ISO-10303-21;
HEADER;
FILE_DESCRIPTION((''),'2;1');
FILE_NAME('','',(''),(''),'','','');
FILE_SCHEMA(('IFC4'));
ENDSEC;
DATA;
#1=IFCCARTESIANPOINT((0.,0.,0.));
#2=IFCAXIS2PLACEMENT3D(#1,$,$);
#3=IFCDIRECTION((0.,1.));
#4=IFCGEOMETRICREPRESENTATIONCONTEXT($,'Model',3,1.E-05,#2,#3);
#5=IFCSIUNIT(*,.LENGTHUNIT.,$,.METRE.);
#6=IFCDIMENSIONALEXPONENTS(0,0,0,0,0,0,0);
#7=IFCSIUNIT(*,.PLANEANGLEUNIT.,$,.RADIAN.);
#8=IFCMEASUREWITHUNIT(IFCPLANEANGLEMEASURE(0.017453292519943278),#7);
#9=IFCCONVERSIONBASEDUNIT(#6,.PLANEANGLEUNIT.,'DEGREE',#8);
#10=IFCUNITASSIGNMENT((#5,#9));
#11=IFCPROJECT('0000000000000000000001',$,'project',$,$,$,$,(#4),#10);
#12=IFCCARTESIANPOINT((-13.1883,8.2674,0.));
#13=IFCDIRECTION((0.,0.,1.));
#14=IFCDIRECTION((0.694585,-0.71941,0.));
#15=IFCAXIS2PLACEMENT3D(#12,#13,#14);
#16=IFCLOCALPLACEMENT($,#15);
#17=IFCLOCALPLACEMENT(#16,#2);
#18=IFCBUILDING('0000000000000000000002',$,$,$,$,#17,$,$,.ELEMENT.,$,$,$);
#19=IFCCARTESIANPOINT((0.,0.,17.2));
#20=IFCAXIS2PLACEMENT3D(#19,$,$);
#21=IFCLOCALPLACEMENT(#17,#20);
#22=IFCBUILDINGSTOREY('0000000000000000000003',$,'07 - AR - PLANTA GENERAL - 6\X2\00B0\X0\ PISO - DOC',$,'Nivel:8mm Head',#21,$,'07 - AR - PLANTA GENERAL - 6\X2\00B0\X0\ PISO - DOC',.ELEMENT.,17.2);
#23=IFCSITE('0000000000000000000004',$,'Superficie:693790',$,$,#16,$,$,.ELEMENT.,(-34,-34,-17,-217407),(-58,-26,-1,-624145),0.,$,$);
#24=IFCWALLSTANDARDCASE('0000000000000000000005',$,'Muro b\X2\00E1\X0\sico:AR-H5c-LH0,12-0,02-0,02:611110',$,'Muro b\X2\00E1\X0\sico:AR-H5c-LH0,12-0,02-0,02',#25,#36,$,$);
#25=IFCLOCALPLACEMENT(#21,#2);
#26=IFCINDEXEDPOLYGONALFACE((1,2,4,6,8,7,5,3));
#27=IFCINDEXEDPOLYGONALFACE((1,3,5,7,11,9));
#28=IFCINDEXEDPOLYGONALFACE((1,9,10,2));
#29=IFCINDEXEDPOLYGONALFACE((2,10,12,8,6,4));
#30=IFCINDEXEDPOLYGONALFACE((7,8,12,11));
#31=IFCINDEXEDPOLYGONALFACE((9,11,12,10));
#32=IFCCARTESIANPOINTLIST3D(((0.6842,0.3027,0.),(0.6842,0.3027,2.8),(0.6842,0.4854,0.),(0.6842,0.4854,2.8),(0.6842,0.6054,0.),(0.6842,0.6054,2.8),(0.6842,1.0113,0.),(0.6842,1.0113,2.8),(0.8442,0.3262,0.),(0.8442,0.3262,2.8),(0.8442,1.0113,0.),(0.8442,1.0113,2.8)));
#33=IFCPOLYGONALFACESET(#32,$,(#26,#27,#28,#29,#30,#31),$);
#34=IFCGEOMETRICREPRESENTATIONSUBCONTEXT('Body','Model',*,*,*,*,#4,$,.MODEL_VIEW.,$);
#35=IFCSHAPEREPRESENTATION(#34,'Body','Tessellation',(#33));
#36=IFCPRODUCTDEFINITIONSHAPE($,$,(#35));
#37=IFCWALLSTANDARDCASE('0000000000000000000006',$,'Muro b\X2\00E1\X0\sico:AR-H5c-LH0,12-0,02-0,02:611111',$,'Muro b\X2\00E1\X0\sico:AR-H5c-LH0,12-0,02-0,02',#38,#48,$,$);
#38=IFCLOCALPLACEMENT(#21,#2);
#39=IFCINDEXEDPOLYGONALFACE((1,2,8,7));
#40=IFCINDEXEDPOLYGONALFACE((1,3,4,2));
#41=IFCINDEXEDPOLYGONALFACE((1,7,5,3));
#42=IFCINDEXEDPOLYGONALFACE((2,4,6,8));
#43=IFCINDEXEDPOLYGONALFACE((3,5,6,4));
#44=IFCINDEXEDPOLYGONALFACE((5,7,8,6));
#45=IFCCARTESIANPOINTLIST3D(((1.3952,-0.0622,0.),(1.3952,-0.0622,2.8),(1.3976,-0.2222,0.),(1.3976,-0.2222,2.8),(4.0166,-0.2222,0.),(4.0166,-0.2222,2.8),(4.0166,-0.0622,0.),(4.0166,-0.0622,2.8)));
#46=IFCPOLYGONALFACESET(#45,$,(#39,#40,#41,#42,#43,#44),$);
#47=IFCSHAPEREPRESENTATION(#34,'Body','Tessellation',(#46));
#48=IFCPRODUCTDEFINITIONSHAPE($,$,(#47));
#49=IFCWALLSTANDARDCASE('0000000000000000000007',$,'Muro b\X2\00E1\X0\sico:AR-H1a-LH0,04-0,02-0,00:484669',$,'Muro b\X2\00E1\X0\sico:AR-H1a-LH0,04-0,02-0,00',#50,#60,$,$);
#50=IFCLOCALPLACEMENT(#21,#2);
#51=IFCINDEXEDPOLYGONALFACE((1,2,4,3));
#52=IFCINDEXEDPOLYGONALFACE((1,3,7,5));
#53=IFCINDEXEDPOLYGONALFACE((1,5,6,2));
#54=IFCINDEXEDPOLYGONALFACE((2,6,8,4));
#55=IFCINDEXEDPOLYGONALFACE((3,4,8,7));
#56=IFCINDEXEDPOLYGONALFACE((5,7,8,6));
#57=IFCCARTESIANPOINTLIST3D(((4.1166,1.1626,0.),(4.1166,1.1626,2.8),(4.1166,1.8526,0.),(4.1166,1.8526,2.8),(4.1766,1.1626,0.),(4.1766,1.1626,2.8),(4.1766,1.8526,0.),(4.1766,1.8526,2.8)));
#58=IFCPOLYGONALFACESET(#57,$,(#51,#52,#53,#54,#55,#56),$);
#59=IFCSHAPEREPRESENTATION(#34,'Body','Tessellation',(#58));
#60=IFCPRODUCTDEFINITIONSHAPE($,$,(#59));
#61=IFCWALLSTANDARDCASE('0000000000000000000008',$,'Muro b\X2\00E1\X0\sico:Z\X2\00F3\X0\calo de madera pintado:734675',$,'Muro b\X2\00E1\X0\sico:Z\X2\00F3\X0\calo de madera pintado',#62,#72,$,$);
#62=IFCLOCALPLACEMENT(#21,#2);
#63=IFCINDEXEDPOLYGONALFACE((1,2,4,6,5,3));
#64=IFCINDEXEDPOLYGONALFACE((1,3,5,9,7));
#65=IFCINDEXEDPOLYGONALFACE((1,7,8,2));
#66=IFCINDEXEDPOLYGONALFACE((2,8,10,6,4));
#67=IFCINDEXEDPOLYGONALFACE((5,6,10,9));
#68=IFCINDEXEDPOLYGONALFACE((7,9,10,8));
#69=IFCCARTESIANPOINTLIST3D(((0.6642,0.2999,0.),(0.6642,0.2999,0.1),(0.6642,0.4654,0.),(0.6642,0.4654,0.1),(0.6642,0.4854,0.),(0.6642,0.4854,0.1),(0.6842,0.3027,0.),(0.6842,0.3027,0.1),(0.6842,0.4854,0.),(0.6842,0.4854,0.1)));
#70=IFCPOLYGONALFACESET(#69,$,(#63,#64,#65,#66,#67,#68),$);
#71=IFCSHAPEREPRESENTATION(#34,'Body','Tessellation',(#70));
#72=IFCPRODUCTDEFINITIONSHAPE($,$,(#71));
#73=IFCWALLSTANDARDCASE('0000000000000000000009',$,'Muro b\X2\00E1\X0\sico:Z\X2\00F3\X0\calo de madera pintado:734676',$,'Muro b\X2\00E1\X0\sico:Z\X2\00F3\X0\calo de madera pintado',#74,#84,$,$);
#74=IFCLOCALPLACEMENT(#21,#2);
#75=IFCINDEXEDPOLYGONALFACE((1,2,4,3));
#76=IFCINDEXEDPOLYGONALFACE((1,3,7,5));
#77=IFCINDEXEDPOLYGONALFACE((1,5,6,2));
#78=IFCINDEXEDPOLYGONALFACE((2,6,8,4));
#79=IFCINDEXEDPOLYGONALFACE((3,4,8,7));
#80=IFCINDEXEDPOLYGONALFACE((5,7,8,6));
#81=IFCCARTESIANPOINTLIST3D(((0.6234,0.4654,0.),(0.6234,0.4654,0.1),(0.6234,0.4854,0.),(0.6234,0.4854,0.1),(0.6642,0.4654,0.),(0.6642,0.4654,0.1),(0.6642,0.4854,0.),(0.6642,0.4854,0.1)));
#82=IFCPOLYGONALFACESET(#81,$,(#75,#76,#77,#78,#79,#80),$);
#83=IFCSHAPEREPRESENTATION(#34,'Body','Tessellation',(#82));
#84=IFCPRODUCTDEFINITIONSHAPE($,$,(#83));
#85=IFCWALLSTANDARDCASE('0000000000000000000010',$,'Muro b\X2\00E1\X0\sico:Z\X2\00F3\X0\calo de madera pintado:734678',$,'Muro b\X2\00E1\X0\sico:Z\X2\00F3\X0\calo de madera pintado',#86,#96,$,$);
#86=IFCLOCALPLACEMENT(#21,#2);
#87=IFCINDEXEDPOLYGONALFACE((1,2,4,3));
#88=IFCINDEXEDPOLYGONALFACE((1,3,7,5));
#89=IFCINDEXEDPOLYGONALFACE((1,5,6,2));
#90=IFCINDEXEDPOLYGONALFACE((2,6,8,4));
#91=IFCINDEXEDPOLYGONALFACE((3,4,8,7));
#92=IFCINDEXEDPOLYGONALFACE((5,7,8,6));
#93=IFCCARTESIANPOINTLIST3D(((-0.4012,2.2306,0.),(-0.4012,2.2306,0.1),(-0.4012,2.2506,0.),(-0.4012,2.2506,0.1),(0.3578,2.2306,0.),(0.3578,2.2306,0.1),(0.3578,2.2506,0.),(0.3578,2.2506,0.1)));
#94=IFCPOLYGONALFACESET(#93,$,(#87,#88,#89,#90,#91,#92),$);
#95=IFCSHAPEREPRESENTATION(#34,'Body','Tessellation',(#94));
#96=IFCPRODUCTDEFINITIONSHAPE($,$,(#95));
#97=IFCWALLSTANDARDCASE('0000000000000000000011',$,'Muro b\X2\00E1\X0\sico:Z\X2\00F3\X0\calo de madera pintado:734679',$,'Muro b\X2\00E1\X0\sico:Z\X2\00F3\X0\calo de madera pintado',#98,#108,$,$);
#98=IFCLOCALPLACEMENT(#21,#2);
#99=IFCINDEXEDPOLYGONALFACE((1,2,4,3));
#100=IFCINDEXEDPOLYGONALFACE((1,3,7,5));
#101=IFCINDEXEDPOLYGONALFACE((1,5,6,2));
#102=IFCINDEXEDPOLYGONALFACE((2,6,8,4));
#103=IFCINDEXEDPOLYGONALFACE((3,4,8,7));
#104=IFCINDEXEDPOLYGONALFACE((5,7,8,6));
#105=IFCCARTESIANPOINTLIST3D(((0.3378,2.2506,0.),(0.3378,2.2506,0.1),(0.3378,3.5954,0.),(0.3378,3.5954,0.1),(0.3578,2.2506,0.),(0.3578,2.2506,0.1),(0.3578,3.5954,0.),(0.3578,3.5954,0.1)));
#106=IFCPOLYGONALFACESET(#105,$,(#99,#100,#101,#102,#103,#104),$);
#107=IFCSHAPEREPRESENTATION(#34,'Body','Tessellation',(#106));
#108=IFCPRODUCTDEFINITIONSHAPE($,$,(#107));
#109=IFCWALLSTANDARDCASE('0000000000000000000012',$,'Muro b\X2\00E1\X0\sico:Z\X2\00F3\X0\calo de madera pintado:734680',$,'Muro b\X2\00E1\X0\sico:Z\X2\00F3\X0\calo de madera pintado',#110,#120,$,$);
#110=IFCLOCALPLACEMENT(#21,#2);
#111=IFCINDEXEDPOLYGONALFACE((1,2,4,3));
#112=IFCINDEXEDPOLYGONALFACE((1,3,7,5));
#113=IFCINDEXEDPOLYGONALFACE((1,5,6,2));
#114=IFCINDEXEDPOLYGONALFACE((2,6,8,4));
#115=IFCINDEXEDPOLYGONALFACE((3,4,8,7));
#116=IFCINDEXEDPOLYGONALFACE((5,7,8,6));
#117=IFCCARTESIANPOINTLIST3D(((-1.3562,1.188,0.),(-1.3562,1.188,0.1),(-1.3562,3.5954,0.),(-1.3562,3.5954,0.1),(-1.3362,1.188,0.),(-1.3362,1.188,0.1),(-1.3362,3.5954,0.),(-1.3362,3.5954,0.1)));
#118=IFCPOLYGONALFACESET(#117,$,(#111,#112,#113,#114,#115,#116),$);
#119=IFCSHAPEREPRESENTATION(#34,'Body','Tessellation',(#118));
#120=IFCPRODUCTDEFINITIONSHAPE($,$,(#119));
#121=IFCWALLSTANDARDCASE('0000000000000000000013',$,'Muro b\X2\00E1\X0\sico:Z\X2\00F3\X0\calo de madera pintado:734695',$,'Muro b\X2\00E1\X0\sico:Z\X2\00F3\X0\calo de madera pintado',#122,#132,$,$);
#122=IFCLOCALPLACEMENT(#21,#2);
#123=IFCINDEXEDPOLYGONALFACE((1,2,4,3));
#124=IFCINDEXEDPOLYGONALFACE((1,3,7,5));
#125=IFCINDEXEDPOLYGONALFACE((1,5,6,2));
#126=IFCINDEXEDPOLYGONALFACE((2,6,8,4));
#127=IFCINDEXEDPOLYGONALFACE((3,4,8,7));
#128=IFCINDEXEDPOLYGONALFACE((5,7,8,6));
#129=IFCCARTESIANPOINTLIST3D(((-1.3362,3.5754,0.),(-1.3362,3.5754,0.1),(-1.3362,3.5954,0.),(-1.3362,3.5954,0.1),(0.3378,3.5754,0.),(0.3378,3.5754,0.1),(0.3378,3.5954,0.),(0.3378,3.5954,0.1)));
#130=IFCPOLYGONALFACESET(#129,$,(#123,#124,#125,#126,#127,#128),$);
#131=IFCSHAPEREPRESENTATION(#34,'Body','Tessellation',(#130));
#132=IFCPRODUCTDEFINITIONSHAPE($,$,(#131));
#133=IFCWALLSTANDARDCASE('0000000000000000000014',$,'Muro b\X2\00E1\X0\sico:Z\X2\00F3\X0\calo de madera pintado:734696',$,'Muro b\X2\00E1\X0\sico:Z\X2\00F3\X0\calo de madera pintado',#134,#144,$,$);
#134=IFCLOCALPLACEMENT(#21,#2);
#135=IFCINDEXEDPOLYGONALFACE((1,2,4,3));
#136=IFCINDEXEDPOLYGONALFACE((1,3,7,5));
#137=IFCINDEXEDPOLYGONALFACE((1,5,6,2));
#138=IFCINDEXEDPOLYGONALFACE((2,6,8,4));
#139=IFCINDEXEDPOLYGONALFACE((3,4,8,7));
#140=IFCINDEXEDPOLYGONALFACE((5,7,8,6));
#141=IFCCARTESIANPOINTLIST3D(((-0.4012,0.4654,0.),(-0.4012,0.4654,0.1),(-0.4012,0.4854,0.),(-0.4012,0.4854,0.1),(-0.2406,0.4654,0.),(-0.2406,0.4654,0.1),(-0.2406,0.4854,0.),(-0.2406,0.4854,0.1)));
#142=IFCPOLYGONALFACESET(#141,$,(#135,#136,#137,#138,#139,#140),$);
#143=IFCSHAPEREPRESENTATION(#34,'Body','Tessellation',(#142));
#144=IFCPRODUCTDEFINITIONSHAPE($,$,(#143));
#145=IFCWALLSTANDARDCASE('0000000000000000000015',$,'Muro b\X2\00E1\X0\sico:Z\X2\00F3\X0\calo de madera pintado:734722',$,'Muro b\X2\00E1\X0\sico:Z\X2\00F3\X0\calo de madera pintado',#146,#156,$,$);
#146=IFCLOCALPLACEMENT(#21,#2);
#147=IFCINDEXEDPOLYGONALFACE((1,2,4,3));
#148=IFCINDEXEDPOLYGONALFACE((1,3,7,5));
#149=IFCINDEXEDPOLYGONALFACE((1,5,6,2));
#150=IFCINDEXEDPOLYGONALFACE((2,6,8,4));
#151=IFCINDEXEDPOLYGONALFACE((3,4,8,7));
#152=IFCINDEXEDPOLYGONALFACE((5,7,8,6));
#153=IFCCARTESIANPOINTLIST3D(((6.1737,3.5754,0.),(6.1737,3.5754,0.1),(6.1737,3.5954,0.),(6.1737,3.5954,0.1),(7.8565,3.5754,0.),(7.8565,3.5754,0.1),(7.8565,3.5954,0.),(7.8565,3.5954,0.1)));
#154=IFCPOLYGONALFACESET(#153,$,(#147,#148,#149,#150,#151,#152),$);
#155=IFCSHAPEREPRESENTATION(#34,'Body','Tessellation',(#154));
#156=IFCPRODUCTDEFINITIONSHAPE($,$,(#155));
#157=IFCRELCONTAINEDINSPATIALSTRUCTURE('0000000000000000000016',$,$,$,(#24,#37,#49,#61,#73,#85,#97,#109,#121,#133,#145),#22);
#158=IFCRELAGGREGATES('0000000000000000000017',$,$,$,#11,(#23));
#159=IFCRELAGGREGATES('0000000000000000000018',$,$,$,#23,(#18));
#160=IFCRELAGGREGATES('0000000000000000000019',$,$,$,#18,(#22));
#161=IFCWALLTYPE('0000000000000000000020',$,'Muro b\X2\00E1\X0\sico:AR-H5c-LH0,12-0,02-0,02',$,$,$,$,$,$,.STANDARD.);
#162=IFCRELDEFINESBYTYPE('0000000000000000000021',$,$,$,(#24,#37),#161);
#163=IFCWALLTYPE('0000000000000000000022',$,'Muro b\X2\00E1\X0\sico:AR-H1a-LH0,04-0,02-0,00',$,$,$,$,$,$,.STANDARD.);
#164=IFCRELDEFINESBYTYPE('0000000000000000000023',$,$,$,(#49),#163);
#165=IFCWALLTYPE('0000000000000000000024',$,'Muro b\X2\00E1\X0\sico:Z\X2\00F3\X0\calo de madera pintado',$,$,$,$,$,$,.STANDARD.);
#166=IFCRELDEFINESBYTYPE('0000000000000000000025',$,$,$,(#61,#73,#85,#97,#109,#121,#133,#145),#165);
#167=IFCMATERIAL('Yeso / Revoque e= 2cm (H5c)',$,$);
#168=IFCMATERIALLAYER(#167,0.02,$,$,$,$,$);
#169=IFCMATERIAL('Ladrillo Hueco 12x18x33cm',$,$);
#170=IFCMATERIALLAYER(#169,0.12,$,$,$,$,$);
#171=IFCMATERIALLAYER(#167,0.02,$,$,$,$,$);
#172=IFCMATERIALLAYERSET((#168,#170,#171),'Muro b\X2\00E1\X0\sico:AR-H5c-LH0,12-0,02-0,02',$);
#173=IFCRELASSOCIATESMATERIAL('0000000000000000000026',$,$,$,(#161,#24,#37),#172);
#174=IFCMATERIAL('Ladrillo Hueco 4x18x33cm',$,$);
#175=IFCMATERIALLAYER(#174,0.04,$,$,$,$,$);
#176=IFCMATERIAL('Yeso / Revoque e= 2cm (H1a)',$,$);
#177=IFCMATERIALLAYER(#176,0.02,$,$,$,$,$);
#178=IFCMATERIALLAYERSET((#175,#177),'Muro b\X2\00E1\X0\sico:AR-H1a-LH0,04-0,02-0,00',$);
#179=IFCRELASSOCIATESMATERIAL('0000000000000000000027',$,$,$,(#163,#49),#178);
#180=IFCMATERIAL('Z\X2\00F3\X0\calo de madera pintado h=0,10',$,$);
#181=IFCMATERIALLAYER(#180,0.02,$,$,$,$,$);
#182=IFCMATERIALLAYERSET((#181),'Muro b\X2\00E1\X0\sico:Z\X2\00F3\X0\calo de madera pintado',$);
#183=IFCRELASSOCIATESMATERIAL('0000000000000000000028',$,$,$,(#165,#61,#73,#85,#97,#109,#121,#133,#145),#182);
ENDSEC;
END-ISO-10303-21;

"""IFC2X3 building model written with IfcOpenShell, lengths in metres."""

from ifc_helpers import new_model, entity, si_unit, converted_unit, direction, frame, frame_2d, origin, place, context, subcontext, project, spatial, polyline, rectangle, outline, extrude, material, layer, layer_set, layer_usage, type_object, element, save


model = new_model("IFC2X3")

# Units and contexts
model_context = context("Model", 3, precision=1e-05, world=origin(), true_north=direction((0.0, 1.0)))
body_context = subcontext(model_context, "Body", "Model", "MODEL_VIEW")
ifc_project = project(units=[si_unit("LENGTHUNIT", "METRE"), converted_unit("PLANEANGLEUNIT", "DEGREE", entity("IfcPlaneAngleMeasure", 0.017453292519943278), si_unit("PLANEANGLEUNIT", "RADIAN"), dimensions=[0, 0, 0, 0, 0, 0, 0])], contexts=[model_context])

# Site, building, storey
site_placement = place(None, frame((-13.1883, 8.2674, 0.0), z_axis=(0.0, 0.0, 1.0), x_axis=(0.694585, -0.71941, 0.0)))
site = spatial("IfcSite", under=ifc_project, at=site_placement, Name="Superficie:693790", CompositionType="ELEMENT", RefLatitude=(-34, -34, -17, -217407), RefLongitude=(-58, -26, -1, -624145), RefElevation=0.0)
building_placement = place(site_placement, origin())
building = spatial("IfcBuilding", under=site, at=building_placement, CompositionType="ELEMENT")
storey_placement = place(building_placement, frame((0.0, 0.0, 17.2)))
storey = spatial("IfcBuildingStorey", under=building, at=storey_placement, Name="07 - AR - PLANTA GENERAL - 6° PISO - DOC", ObjectType="Nivel:8mm Head", LongName="07 - AR - PLANTA GENERAL - 6° PISO - DOC", CompositionType="ELEMENT", Elevation=17.2)

# Walls
ifc_material_1 = material(Name="Yeso / Revoque e= 2cm (H5c)")
ifc_layer_1 = layer(ifc_material_1, 0.02)
ifc_material_2 = material(Name="Ladrillo Hueco 12x18x33cm")
ifc_layer_2 = layer(ifc_material_2, 0.12)
ifc_layer_3 = layer(ifc_material_1, 0.02)
ifc_layer_set_1 = layer_set([ifc_layer_1, ifc_layer_2, ifc_layer_3], Name="Muro básico:AR-H5c-LH0,12-0,02-0,02")
ifc_layer_usage_1 = layer_usage(ifc_layer_set_1, "AXIS2", "NEGATIVE", 0.08)
wall_type_1 = type_object("IfcWallType", Name="Muro básico:AR-H5c-LH0,12-0,02-0,02", PredefinedType="STANDARD", material=ifc_layer_set_1)
wall_1_placement = place(storey_placement, frame((0.7642, 0.3027, 0.0), z_axis=(0.0, 0.0, 1.0), x_axis=(0.0, 1.0, 0.0)))
element("IfcWallStandardCase", 1, at=wall_1_placement, inside=storey, type_object=wall_type_1, material=ifc_layer_usage_1, Name="Muro básico:AR-H5c-LH0,12-0,02-0,02:611110", ObjectType="Muro básico:AR-H5c-LH0,12-0,02-0,02", context=body_context, shape_type="SweptSolid", body=[
    extrude(outline(polyline([(0.7086, -0.08), (0.7086, 0.08), (0.3027, 0.08), (0.1827, 0.08), (0.0, 0.08), (0.0235, -0.08), (0.7086, -0.08)])), origin(), (0.0, 0.0, 1.0), 2.8),
])
ifc_layer_usage_2 = layer_usage(ifc_layer_set_1, "AXIS2", "NEGATIVE", 0.08)
wall_2_placement = place(storey_placement, frame((1.3952, -0.1422, 0.0)))
element("IfcWallStandardCase", 2, at=wall_2_placement, inside=storey, type_object=wall_type_1, material=ifc_layer_usage_2, Name="Muro básico:AR-H5c-LH0,12-0,02-0,02:611111", ObjectType="Muro básico:AR-H5c-LH0,12-0,02-0,02", context=body_context, shape_type="SweptSolid", body=[
    extrude(outline(polyline([(2.6214, -0.08), (2.6214, 0.08), (0.0, 0.08), (0.0024, -0.08), (2.6214, -0.08)])), origin(), (0.0, 0.0, 1.0), 2.8),
])
ifc_material_3 = material(Name="Ladrillo Hueco 4x18x33cm")
ifc_layer_4 = layer(ifc_material_3, 0.04)
ifc_material_4 = material(Name="Yeso / Revoque e= 2cm (H1a)")
ifc_layer_5 = layer(ifc_material_4, 0.02)
ifc_layer_set_2 = layer_set([ifc_layer_4, ifc_layer_5], Name="Muro básico:AR-H1a-LH0,04-0,02-0,00")
ifc_layer_usage_3 = layer_usage(ifc_layer_set_2, "AXIS2", "NEGATIVE", 0.03)
wall_type_2 = type_object("IfcWallType", Name="Muro básico:AR-H1a-LH0,04-0,02-0,00", PredefinedType="STANDARD", material=ifc_layer_set_2)
wall_3_placement = place(storey_placement, frame((4.1466, 1.1626, 0.0), z_axis=(0.0, 0.0, 1.0), x_axis=(0.0, 1.0, 0.0)))
element("IfcWallStandardCase", 3, at=wall_3_placement, inside=storey, type_object=wall_type_2, material=ifc_layer_usage_3, Name="Muro básico:AR-H1a-LH0,04-0,02-0,00:484669", ObjectType="Muro básico:AR-H1a-LH0,04-0,02-0,00", context=body_context, shape_type="SweptSolid", body=[
    extrude(rectangle(XDim=0.69, YDim=0.06, at=frame_2d((0.345, 0.0), x_axis=(-1.0, 0.0))), origin(), (0.0, 0.0, 1.0), 2.8),
])
ifc_material_5 = material(Name="Zócalo de madera pintado h=0,10")
ifc_layer_6 = layer(ifc_material_5, 0.02)
ifc_layer_set_3 = layer_set([ifc_layer_6], Name="Muro básico:Zócalo de madera pintado")
wall_type_3 = type_object("IfcWallType", Name="Muro básico:Zócalo de madera pintado", PredefinedType="STANDARD", material=ifc_layer_set_3)
ifc_layer_usage_4 = layer_usage(ifc_layer_set_3, "AXIS2", "NEGATIVE", 0.01)
wall_4_placement = place(storey_placement, frame((0.6742, 0.2999, 0.0), z_axis=(0.0, 0.0, 1.0), x_axis=(0.0, 1.0, 0.0)))
element("IfcWallStandardCase", 4, at=wall_4_placement, inside=storey, type_object=wall_type_3, material=ifc_layer_usage_4, Name="Muro básico:Zócalo de madera pintado:734675", ObjectType="Muro básico:Zócalo de madera pintado", context=body_context, shape_type="SweptSolid", body=[
    extrude(outline(polyline([(0.1855, -0.01), (0.1855, 0.01), (0.1655, 0.01), (0.0, 0.01), (0.0027, -0.01), (0.1855, -0.01)])), origin(), (0.0, 0.0, 1.0), 0.1),
])
ifc_layer_usage_5 = layer_usage(ifc_layer_set_3, "AXIS2", "NEGATIVE", 0.01)
wall_5_placement = place(storey_placement, frame((0.6642, 0.4754, 0.0), z_axis=(0.0, 0.0, 1.0), x_axis=(-1.0, 0.0, 0.0)))
element("IfcWallStandardCase", 5, at=wall_5_placement, inside=storey, type_object=wall_type_3, material=ifc_layer_usage_5, Name="Muro básico:Zócalo de madera pintado:734676", ObjectType="Muro básico:Zócalo de madera pintado", context=body_context, shape_type="SweptSolid", body=[
    extrude(rectangle(XDim=0.0408, YDim=0.02, at=frame_2d((0.0204, 0.0), x_axis=(-1.0, 0.0))), origin(), (0.0, 0.0, 1.0), 0.1),
])
ifc_layer_usage_6 = layer_usage(ifc_layer_set_3, "AXIS2", "NEGATIVE", 0.01)
wall_6_placement = place(storey_placement, frame((-0.4012, 2.2406, 0.0)))
element("IfcWallStandardCase", 6, at=wall_6_placement, inside=storey, type_object=wall_type_3, material=ifc_layer_usage_6, Name="Muro básico:Zócalo de madera pintado:734678", ObjectType="Muro básico:Zócalo de madera pintado", context=body_context, shape_type="SweptSolid", body=[
    extrude(rectangle(XDim=0.759, YDim=0.02, at=frame_2d((0.3795, 0.0), x_axis=(-1.0, 0.0))), origin(), (0.0, 0.0, 1.0), 0.1),
])
ifc_layer_usage_7 = layer_usage(ifc_layer_set_3, "AXIS2", "NEGATIVE", 0.01)
wall_7_placement = place(storey_placement, frame((0.3478, 2.2506, 0.0), z_axis=(0.0, 0.0, 1.0), x_axis=(0.0, 1.0, 0.0)))
element("IfcWallStandardCase", 7, at=wall_7_placement, inside=storey, type_object=wall_type_3, material=ifc_layer_usage_7, Name="Muro básico:Zócalo de madera pintado:734679", ObjectType="Muro básico:Zócalo de madera pintado", context=body_context, shape_type="SweptSolid", body=[
    extrude(rectangle(XDim=1.3448, YDim=0.02, at=frame_2d((0.6724, 0.0), x_axis=(-1.0, 0.0))), origin(), (0.0, 0.0, 1.0), 0.1),
])
ifc_layer_usage_8 = layer_usage(ifc_layer_set_3, "AXIS2", "NEGATIVE", 0.01)
wall_8_placement = place(storey_placement, frame((-1.3462, 3.5954, 0.0), z_axis=(0.0, 0.0, 1.0), x_axis=(0.0, -1.0, 0.0)))
element("IfcWallStandardCase", 8, at=wall_8_placement, inside=storey, type_object=wall_type_3, material=ifc_layer_usage_8, Name="Muro básico:Zócalo de madera pintado:734680", ObjectType="Muro básico:Zócalo de madera pintado", context=body_context, shape_type="SweptSolid", body=[
    extrude(rectangle(XDim=2.4074, YDim=0.02, at=frame_2d((1.2037, 0.0), x_axis=(-1.0, 0.0))), origin(), (0.0, 0.0, 1.0), 0.1),
])
ifc_layer_usage_9 = layer_usage(ifc_layer_set_3, "AXIS2", "NEGATIVE", 0.01)
wall_9_placement = place(storey_placement, frame((0.3378, 3.5854, 0.0), z_axis=(0.0, 0.0, 1.0), x_axis=(-1.0, 0.0, 0.0)))
element("IfcWallStandardCase", 9, at=wall_9_placement, inside=storey, type_object=wall_type_3, material=ifc_layer_usage_9, Name="Muro básico:Zócalo de madera pintado:734695", ObjectType="Muro básico:Zócalo de madera pintado", context=body_context, shape_type="SweptSolid", body=[
    extrude(rectangle(XDim=1.674, YDim=0.02, at=frame_2d((0.837, 0.0), x_axis=(-1.0, 0.0))), origin(), (0.0, 0.0, 1.0), 0.1),
])
ifc_layer_usage_10 = layer_usage(ifc_layer_set_3, "AXIS2", "NEGATIVE", 0.01)
wall_10_placement = place(storey_placement, frame((-0.2406, 0.4754, 0.0), z_axis=(0.0, 0.0, 1.0), x_axis=(-1.0, 0.0, 0.0)))
element("IfcWallStandardCase", 10, at=wall_10_placement, inside=storey, type_object=wall_type_3, material=ifc_layer_usage_10, Name="Muro básico:Zócalo de madera pintado:734696", ObjectType="Muro básico:Zócalo de madera pintado", context=body_context, shape_type="SweptSolid", body=[
    extrude(rectangle(XDim=0.1606, YDim=0.02, at=frame_2d((0.0803, 0.0), x_axis=(-1.0, 0.0))), origin(), (0.0, 0.0, 1.0), 0.1),
])
ifc_layer_usage_11 = layer_usage(ifc_layer_set_3, "AXIS2", "NEGATIVE", 0.01)
wall_11_placement = place(storey_placement, frame((6.1737, 3.5854, 0.0)))
element("IfcWallStandardCase", 11, at=wall_11_placement, inside=storey, type_object=wall_type_3, material=ifc_layer_usage_11, Name="Muro básico:Zócalo de madera pintado:734722", ObjectType="Muro básico:Zócalo de madera pintado", context=body_context, shape_type="SweptSolid", body=[
    extrude(rectangle(XDim=1.6828, YDim=0.02, at=frame_2d((0.8414, 0.0), x_axis=(-1.0, 0.0))), origin(), (0.0, 0.0, 1.0), 0.1),
])

save(model, "model.ifc")
